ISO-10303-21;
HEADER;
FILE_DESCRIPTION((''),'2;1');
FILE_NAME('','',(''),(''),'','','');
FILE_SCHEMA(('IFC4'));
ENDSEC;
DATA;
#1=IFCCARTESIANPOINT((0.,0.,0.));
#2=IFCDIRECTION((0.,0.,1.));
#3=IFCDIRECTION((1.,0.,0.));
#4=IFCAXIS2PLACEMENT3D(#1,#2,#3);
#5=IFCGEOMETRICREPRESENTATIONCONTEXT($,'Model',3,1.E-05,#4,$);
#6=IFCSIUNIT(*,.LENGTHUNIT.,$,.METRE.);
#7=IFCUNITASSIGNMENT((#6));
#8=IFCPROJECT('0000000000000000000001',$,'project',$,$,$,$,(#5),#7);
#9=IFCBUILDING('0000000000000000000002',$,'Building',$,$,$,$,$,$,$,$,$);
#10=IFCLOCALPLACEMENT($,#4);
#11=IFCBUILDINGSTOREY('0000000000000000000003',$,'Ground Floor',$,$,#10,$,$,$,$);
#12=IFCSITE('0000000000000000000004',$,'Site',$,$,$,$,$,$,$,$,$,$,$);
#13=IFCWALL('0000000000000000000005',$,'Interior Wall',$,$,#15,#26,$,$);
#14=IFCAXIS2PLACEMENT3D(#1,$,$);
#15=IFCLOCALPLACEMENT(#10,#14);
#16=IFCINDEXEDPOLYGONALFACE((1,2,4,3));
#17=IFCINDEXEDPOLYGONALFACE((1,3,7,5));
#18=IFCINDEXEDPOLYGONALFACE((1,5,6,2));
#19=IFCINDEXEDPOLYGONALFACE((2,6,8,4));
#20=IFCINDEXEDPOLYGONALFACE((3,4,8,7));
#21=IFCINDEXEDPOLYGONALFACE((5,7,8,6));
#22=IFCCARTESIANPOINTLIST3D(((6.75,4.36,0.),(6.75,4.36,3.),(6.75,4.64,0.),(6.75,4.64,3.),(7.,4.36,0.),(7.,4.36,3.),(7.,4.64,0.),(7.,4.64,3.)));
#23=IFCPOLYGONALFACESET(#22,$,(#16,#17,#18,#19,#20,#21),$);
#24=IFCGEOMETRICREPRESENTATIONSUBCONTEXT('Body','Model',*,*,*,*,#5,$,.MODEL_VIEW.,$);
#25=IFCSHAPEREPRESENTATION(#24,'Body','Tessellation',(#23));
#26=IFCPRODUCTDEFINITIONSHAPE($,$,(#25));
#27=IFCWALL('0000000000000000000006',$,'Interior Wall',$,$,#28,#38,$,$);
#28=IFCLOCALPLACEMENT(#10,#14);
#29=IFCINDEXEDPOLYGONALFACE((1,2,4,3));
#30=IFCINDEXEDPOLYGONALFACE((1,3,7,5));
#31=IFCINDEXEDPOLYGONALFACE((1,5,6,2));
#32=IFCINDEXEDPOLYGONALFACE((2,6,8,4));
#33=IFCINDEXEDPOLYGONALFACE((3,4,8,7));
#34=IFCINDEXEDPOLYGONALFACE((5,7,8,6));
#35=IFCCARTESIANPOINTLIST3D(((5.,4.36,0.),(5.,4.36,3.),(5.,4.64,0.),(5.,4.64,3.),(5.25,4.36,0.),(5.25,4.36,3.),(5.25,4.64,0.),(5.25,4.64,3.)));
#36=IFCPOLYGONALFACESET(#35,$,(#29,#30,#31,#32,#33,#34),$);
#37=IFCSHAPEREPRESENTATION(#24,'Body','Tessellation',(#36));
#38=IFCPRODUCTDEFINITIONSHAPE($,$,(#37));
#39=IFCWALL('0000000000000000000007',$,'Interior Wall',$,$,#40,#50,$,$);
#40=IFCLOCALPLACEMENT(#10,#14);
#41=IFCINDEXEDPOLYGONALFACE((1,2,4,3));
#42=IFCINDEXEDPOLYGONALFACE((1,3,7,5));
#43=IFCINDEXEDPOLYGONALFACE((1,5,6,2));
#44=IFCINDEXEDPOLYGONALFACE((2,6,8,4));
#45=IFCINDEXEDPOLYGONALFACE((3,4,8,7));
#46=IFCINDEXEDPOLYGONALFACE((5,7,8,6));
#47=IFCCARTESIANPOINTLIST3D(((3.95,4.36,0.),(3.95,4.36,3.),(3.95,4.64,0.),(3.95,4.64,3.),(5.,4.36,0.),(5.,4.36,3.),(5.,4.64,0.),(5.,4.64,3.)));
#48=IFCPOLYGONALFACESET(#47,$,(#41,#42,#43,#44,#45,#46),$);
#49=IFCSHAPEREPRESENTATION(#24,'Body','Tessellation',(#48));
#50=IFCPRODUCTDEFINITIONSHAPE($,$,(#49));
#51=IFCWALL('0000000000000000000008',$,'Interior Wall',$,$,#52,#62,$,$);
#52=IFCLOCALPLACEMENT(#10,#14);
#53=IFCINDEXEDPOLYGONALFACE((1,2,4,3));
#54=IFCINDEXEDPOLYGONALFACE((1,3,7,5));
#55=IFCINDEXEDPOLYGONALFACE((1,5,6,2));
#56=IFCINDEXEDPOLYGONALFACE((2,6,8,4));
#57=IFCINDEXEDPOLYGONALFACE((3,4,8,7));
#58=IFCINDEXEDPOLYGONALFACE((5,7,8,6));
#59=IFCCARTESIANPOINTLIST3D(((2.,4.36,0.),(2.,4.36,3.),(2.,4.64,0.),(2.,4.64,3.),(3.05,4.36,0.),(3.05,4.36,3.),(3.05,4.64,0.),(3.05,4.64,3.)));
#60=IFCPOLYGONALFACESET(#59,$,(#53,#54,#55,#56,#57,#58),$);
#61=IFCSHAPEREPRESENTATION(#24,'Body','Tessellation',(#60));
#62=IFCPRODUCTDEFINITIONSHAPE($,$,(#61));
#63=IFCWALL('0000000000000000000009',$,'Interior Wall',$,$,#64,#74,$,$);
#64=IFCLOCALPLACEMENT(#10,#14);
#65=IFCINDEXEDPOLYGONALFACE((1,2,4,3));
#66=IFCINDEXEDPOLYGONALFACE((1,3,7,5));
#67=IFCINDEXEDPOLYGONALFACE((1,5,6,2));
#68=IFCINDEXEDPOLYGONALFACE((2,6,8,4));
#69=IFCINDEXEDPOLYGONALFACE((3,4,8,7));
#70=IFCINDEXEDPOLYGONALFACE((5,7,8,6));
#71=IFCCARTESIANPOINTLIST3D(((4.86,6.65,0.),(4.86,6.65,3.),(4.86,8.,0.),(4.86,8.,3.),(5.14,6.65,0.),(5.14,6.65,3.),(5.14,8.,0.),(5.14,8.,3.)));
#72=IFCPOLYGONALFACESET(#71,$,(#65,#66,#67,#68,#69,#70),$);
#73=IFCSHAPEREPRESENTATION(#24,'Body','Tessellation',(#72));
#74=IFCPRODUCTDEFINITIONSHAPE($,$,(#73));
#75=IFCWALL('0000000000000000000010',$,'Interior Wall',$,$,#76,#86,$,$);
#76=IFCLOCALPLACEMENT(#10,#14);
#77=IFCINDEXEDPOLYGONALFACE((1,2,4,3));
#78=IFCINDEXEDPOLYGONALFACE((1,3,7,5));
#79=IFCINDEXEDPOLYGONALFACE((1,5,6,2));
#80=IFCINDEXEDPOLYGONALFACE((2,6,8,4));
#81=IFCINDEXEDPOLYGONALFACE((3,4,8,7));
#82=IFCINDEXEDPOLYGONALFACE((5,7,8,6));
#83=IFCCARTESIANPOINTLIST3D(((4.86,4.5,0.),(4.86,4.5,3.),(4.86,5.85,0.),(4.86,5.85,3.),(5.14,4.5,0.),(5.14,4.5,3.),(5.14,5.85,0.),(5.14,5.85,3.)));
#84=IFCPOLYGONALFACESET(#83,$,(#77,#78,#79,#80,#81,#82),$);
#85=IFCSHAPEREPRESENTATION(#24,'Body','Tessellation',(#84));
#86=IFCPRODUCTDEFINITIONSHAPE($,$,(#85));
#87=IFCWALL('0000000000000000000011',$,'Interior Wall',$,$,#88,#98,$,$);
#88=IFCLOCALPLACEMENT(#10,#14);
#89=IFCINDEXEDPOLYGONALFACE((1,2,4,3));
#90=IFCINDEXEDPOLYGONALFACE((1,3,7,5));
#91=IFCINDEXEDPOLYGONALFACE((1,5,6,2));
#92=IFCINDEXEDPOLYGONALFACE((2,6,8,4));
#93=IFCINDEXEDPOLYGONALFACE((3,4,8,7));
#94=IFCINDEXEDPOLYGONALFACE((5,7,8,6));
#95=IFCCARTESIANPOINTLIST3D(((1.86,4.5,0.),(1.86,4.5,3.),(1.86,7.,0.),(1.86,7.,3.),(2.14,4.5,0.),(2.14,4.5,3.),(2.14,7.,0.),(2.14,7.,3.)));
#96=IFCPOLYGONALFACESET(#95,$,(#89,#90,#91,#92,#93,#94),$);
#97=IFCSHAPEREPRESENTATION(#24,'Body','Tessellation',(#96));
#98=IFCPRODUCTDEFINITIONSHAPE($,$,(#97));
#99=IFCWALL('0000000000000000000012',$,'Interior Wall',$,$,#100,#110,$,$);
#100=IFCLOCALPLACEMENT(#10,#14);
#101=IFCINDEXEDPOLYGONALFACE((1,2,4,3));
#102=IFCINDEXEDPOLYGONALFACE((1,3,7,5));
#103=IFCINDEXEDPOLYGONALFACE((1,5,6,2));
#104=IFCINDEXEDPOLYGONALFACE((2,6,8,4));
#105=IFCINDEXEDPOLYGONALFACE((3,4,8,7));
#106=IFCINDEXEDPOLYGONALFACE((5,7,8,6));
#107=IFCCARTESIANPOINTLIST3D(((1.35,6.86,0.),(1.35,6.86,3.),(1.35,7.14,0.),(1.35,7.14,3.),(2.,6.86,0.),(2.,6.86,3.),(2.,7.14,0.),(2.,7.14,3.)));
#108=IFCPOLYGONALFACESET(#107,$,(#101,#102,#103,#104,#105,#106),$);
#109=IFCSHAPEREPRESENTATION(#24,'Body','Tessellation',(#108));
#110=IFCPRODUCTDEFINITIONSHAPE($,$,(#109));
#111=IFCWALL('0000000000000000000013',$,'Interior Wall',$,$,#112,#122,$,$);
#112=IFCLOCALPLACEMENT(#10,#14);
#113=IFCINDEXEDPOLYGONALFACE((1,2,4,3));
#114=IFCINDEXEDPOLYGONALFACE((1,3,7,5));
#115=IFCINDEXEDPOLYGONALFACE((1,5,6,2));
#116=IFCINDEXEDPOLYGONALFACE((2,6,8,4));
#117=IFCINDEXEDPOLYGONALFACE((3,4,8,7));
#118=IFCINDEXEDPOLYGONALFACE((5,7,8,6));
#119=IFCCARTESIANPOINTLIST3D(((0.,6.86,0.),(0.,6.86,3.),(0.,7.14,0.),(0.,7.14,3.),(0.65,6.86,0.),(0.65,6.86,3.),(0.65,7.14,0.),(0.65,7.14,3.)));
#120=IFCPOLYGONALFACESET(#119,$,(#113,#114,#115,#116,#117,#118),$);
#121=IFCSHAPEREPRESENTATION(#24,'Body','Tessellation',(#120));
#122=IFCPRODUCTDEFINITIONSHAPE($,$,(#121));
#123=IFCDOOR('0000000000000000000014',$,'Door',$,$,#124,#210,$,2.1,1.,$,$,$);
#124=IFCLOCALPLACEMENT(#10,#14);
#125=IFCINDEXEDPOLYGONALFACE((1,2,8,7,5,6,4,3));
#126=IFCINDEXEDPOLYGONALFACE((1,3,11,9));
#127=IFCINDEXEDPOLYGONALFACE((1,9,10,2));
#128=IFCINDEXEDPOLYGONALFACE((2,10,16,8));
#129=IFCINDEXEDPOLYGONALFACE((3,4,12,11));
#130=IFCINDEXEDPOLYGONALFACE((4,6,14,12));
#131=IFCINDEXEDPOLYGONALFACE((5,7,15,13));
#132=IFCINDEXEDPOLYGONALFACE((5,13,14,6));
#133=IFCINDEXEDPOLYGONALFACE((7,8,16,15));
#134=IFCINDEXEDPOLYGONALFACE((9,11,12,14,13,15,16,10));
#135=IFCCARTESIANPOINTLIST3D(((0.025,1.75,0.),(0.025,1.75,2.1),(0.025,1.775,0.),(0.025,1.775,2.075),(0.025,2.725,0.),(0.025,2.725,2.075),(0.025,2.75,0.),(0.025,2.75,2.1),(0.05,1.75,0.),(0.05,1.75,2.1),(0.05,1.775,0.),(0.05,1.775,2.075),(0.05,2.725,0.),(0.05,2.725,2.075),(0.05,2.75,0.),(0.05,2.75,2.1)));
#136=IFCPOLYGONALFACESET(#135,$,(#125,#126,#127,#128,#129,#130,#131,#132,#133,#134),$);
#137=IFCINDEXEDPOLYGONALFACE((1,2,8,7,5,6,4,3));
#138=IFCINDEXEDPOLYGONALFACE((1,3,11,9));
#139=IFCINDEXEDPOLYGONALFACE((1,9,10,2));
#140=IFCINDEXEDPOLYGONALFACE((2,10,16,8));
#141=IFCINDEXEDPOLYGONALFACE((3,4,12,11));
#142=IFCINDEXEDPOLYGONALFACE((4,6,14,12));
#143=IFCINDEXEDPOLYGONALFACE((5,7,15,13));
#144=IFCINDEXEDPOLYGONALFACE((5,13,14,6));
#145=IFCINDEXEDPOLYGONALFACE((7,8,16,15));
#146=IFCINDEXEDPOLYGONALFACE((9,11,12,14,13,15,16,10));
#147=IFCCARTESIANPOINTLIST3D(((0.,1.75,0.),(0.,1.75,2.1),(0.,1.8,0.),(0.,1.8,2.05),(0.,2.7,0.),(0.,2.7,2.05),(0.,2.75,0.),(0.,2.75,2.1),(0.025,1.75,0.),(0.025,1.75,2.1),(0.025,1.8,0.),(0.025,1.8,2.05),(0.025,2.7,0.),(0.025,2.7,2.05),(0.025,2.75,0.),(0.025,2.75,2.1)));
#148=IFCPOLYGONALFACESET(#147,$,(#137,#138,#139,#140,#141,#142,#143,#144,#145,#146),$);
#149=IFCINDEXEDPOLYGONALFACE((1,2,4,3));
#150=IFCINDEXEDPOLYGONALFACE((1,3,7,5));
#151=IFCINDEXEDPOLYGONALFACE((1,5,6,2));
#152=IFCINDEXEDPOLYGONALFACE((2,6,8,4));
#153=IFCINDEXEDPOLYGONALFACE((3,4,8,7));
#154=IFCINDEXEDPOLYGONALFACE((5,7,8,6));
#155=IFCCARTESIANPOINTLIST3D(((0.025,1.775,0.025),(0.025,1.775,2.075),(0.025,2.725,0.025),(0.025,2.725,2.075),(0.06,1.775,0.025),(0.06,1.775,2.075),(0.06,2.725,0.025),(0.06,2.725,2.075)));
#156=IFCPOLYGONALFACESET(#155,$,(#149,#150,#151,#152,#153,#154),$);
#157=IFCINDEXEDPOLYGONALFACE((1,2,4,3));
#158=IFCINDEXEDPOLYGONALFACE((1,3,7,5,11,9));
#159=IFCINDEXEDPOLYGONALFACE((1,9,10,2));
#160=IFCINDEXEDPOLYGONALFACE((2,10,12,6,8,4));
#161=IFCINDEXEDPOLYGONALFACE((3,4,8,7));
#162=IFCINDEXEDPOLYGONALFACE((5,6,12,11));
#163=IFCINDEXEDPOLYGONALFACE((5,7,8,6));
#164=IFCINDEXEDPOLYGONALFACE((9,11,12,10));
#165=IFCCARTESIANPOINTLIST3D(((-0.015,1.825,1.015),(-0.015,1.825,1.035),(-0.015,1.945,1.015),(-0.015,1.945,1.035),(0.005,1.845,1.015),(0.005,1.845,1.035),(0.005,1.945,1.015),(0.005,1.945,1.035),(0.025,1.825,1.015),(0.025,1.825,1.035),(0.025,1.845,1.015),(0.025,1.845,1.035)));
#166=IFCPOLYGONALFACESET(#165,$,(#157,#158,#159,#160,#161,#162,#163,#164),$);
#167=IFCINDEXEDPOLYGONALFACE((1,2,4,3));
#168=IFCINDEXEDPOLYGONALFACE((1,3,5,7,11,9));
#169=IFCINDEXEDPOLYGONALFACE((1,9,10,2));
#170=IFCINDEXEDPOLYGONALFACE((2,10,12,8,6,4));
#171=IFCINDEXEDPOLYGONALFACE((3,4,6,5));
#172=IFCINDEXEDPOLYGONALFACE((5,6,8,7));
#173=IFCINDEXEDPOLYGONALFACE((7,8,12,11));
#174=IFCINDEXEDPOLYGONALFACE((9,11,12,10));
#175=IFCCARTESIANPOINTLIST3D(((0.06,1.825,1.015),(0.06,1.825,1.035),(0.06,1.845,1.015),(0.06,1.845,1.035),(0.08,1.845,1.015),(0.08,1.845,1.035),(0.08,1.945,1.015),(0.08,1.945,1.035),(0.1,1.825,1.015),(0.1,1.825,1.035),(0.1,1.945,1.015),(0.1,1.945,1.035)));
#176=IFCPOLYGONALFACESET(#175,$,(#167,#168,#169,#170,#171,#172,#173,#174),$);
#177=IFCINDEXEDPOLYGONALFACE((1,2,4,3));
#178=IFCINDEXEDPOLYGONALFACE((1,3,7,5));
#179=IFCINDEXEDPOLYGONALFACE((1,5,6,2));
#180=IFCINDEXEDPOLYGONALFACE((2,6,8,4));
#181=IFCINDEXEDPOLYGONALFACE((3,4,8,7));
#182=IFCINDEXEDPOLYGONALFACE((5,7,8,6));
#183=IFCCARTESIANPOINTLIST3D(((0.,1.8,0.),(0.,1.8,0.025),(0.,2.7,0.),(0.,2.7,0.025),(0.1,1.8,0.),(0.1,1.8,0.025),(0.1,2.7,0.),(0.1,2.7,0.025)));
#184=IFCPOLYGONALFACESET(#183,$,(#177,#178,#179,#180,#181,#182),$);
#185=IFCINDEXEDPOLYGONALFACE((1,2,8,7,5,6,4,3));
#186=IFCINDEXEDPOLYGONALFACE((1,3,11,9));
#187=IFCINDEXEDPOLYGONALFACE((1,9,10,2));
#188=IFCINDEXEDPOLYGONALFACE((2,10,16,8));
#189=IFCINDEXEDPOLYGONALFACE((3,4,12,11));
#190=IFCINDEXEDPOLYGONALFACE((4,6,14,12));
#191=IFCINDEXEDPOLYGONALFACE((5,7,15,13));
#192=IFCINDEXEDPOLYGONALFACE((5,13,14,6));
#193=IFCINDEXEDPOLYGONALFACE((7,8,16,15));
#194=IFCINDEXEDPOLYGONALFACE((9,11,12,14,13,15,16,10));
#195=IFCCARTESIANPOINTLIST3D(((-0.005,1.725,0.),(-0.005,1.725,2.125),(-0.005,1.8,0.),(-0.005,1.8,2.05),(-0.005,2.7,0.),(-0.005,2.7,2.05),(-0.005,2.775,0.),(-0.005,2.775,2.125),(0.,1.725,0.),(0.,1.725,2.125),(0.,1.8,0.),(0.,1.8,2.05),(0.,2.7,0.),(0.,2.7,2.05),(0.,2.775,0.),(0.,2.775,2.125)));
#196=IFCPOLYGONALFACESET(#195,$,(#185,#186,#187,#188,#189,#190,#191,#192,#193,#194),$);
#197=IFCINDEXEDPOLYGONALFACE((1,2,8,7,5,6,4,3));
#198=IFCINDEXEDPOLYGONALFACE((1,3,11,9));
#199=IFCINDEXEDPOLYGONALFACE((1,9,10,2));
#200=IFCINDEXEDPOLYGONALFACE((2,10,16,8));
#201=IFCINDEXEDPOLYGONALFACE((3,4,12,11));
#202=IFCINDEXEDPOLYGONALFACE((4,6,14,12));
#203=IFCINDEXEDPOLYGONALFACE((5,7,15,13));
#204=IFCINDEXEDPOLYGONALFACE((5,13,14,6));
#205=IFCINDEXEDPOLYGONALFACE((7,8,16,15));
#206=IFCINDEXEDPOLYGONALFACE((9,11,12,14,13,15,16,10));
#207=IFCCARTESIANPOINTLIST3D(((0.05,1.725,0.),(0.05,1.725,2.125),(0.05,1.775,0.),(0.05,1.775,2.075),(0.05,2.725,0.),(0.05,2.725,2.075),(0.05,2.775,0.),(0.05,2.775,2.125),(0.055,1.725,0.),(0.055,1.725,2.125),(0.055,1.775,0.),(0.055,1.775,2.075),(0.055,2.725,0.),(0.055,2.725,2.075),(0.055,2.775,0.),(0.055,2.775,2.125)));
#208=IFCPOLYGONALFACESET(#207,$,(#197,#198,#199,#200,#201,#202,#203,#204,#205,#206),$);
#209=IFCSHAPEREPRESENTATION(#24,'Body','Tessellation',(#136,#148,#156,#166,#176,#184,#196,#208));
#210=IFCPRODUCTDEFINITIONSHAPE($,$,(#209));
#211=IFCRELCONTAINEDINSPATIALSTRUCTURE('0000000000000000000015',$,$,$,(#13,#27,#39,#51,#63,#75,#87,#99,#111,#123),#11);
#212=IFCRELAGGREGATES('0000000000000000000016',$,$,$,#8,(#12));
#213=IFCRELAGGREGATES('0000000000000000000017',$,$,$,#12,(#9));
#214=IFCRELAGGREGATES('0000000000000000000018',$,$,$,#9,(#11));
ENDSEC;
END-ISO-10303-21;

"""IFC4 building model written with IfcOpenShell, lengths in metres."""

from ifc_helpers import new_model, si_unit, frame, origin_with_axes, place, context, subcontext, project, spatial, line, indexed_curve, outline, extrude, element, save


model = new_model("IFC4")

# Units and contexts
model_context = context("Model", 3, precision=1e-05, world=origin_with_axes())
body_context = subcontext(model_context, "Body", "Model", "MODEL_VIEW")
ifc_project = project(units=[si_unit("LENGTHUNIT", "METRE")], contexts=[model_context])

# Site, building, storey
site = spatial("IfcSite", under=ifc_project, Name="Site")
building = spatial("IfcBuilding", under=site, Name="Building")
storey_placement = place(None, origin_with_axes())
storey = spatial("IfcBuildingStorey", under=building, at=storey_placement, Name="Ground Floor")

# Walls
for number, where, z_axis, x_axis, name in (
    (1, (7.0, 4.5, 0.0), (0.0, 0.0, 1.0), (-1.0, 0.0, 0.0), "Interior Wall"),
    (2, (5.25, 4.5, 0.0), (0.0, 0.0, 1.0), (-1.0, 0.0, 0.0), "Interior Wall"),
):
    element("IfcWall", number, at=place(storey_placement, frame(where, z_axis=z_axis, x_axis=x_axis)), inside=storey, Name=name, context=body_context, shape_type="SweptSolid", body=[
        extrude(outline(indexed_curve([(0.0, 0.0), (0.0, 0.28), (0.25, 0.28), (0.25, 0.0), (0.0, 0.0)], self_intersect=False)), frame((0.0, -0.14, 0.0), z_axis=(0.0, 0.0, 1.0), x_axis=(1.0, 0.0, 0.0)), (0.0, 0.0, 1.0), 3.0),
    ])
for number, where, z_axis, x_axis, name in (
    (3, (5.0, 4.5, 0.0), (0.0, 0.0, 1.0), (-1.0, 0.0, 0.0), "Interior Wall"),
    (4, (3.05, 4.5, 0.0), (0.0, 0.0, 1.0), (-1.0, 0.0, 0.0), "Interior Wall"),
):
    element("IfcWall", number, at=place(storey_placement, frame(where, z_axis=z_axis, x_axis=x_axis)), inside=storey, Name=name, context=body_context, shape_type="SweptSolid", body=[
        extrude(outline(indexed_curve([(0.0, 0.0), (0.0, 0.28), (1.05, 0.28), (1.05, 0.0), (0.0, 0.0)], self_intersect=False)), frame((0.0, -0.14, 0.0), z_axis=(0.0, 0.0, 1.0), x_axis=(1.0, 0.0, 0.0)), (0.0, 0.0, 1.0), 3.0),
    ])
for number, where, z_axis, x_axis, name in (
    (5, (5.0, 8.0, 0.0), (0.0, 0.0, 1.0), (0.0, -1.0, 0.0), "Interior Wall"),
    (6, (5.0, 5.85, 0.0), (0.0, 0.0, 1.0), (0.0, -1.0, 0.0), "Interior Wall"),
):
    element("IfcWall", number, at=place(storey_placement, frame(where, z_axis=z_axis, x_axis=x_axis)), inside=storey, Name=name, context=body_context, shape_type="SweptSolid", body=[
        extrude(outline(indexed_curve([(0.0, 0.0), (0.0, 0.28), (1.35, 0.28), (1.35, 0.0), (0.0, 0.0)], self_intersect=False)), frame((0.0, -0.14, 0.0), z_axis=(0.0, 0.0, 1.0), x_axis=(1.0, 0.0, 0.0)), (0.0, 0.0, 1.0), 3.0),
    ])
wall_1_placement = place(storey_placement, frame((2.0, 4.5, 0.0), z_axis=(0.0, 0.0, 1.0), x_axis=(0.0, 1.0, 0.0)))
element("IfcWall", 7, at=wall_1_placement, inside=storey, Name="Interior Wall", context=body_context, shape_type="SweptSolid", body=[
    extrude(outline(indexed_curve([(0.0, 0.0), (0.0, 0.28), (2.5, 0.28), (2.5, 0.0), (0.0, 0.0)], self_intersect=False)), frame((0.0, -0.14, 0.0), z_axis=(0.0, 0.0, 1.0), x_axis=(1.0, 0.0, 0.0)), (0.0, 0.0, 1.0), 3.0),
])
for number, where, z_axis, x_axis, name in (
    (8, (2.0, 7.0, 0.0), (0.0, 0.0, 1.0), (-1.0, 0.0, 0.0), "Interior Wall"),
    (9, (0.65, 7.0, 0.0), (0.0, 0.0, 1.0), (-1.0, 0.0, 0.0), "Interior Wall"),
):
    element("IfcWall", number, at=place(storey_placement, frame(where, z_axis=z_axis, x_axis=x_axis)), inside=storey, Name=name, context=body_context, shape_type="SweptSolid", body=[
        extrude(outline(indexed_curve([(0.0, 0.0), (0.0, 0.28), (0.65, 0.28), (0.65, 0.0), (0.0, 0.0)], self_intersect=False)), frame((0.0, -0.14, 0.0), z_axis=(0.0, 0.0, 1.0), x_axis=(1.0, 0.0, 0.0)), (0.0, 0.0, 1.0), 3.0),
    ])

# Door
door_1_placement = place(storey_placement, frame((0.0, 2.75, 0.0), z_axis=(0.0, 0.0, 1.0), x_axis=(0.0, -1.0, 0.0)))
element("IfcDoor", 10, at=door_1_placement, inside=storey, Name="Door", OverallHeight=2.1, OverallWidth=1.0, context=body_context, shape_type="SweptSolid", body=[
    extrude(outline(indexed_curve([(0.0, 0.0), (0.0, 2.1), (1.0, 2.1), (1.0, 0.0), (0.975, 0.0), (0.975, 2.075), (0.025, 2.075), (0.025, 0.0)], segments=[line(1, 2, 3, 4, 5, 6, 7, 8, 1)])), frame((0.0, 0.025, 0.0), z_axis=(0.0, -1.0, 0.0), x_axis=(1.0, 0.0, 0.0)), (0.0, 0.0, -1.0), 0.025),
    extrude(outline(indexed_curve([(0.0, 0.0), (0.0, 2.1), (1.0, 2.1), (1.0, 0.0), (0.95, 0.0), (0.95, 2.05), (0.05, 2.05), (0.05, 0.0)], segments=[line(1, 2, 3, 4, 5, 6, 7, 8, 1)])), frame((0.0, 0.0, 0.0), z_axis=(0.0, -1.0, 0.0), x_axis=(1.0, 0.0, 0.0)), (0.0, 0.0, -1.0), 0.025),
    extrude(outline(indexed_curve([(0.0, 0.0), (0.95, 0.0), (0.95, 0.035), (0.0, 0.035)], segments=[line(1, 2, 3, 4, 1)])), frame((0.025, 0.025, 0.025), z_axis=(0.0, 0.0, 1.0), x_axis=(1.0, 0.0, 0.0)), (0.0, 0.0, 1.0), 2.05),
    extrude(outline(indexed_curve([(0.0, 0.0), (0.0, -0.04), (-0.12, -0.04), (-0.12, -0.02), (-0.02, -0.02), (-0.02, 0.0)], segments=[line(1, 2, 3, 4, 5, 6, 1)])), frame((0.925, 0.025, 1.015), z_axis=(0.0, 0.0, 1.0), x_axis=(1.0, 0.0, 0.0)), (0.0, 0.0, 1.0), 0.02),
    extrude(outline(indexed_curve([(0.0, 0.0), (0.0, 0.04), (-0.12, 0.04), (-0.12, 0.02), (-0.02, 0.02), (-0.02, 0.0)], segments=[line(1, 2, 3, 4, 5, 6, 1)])), frame((0.925, 0.06, 1.015), z_axis=(0.0, 0.0, 1.0), x_axis=(1.0, 0.0, 0.0)), (0.0, 0.0, 1.0), 0.02),
    extrude(outline(indexed_curve([(0.0, 0.0), (0.9, 0.0), (0.9, 0.1), (0.0, 0.1)], segments=[line(1, 2, 3, 4, 1)])), frame((0.05, 0.0, 0.0), z_axis=(0.0, 0.0, 1.0), x_axis=(1.0, 0.0, 0.0)), (0.0, 0.0, 1.0), 0.025),
    extrude(outline(indexed_curve([(0.0, 0.0), (0.0, 2.125), (1.05, 2.125), (1.05, 0.0), (0.975, 0.0), (0.975, 2.05), (0.075, 2.05), (0.075, 0.0)], segments=[line(1, 2, 3, 4, 5, 6, 7, 8, 1)])), frame((-0.025, -0.005, 0.0), z_axis=(0.0, -1.0, 0.0), x_axis=(1.0, 0.0, 0.0)), (0.0, 0.0, -1.0), 0.005),
    extrude(outline(indexed_curve([(0.0, 0.0), (0.0, 2.125), (1.05, 2.125), (1.05, 0.0), (1.0, 0.0), (1.0, 2.075), (0.05, 2.075), (0.05, 0.0)], segments=[line(1, 2, 3, 4, 5, 6, 7, 8, 1)])), frame((-0.025, 0.05, 0.0), z_axis=(0.0, -1.0, 0.0), x_axis=(1.0, 0.0, 0.0)), (0.0, 0.0, -1.0), 0.005),
])

save(model, "model.ifc")
